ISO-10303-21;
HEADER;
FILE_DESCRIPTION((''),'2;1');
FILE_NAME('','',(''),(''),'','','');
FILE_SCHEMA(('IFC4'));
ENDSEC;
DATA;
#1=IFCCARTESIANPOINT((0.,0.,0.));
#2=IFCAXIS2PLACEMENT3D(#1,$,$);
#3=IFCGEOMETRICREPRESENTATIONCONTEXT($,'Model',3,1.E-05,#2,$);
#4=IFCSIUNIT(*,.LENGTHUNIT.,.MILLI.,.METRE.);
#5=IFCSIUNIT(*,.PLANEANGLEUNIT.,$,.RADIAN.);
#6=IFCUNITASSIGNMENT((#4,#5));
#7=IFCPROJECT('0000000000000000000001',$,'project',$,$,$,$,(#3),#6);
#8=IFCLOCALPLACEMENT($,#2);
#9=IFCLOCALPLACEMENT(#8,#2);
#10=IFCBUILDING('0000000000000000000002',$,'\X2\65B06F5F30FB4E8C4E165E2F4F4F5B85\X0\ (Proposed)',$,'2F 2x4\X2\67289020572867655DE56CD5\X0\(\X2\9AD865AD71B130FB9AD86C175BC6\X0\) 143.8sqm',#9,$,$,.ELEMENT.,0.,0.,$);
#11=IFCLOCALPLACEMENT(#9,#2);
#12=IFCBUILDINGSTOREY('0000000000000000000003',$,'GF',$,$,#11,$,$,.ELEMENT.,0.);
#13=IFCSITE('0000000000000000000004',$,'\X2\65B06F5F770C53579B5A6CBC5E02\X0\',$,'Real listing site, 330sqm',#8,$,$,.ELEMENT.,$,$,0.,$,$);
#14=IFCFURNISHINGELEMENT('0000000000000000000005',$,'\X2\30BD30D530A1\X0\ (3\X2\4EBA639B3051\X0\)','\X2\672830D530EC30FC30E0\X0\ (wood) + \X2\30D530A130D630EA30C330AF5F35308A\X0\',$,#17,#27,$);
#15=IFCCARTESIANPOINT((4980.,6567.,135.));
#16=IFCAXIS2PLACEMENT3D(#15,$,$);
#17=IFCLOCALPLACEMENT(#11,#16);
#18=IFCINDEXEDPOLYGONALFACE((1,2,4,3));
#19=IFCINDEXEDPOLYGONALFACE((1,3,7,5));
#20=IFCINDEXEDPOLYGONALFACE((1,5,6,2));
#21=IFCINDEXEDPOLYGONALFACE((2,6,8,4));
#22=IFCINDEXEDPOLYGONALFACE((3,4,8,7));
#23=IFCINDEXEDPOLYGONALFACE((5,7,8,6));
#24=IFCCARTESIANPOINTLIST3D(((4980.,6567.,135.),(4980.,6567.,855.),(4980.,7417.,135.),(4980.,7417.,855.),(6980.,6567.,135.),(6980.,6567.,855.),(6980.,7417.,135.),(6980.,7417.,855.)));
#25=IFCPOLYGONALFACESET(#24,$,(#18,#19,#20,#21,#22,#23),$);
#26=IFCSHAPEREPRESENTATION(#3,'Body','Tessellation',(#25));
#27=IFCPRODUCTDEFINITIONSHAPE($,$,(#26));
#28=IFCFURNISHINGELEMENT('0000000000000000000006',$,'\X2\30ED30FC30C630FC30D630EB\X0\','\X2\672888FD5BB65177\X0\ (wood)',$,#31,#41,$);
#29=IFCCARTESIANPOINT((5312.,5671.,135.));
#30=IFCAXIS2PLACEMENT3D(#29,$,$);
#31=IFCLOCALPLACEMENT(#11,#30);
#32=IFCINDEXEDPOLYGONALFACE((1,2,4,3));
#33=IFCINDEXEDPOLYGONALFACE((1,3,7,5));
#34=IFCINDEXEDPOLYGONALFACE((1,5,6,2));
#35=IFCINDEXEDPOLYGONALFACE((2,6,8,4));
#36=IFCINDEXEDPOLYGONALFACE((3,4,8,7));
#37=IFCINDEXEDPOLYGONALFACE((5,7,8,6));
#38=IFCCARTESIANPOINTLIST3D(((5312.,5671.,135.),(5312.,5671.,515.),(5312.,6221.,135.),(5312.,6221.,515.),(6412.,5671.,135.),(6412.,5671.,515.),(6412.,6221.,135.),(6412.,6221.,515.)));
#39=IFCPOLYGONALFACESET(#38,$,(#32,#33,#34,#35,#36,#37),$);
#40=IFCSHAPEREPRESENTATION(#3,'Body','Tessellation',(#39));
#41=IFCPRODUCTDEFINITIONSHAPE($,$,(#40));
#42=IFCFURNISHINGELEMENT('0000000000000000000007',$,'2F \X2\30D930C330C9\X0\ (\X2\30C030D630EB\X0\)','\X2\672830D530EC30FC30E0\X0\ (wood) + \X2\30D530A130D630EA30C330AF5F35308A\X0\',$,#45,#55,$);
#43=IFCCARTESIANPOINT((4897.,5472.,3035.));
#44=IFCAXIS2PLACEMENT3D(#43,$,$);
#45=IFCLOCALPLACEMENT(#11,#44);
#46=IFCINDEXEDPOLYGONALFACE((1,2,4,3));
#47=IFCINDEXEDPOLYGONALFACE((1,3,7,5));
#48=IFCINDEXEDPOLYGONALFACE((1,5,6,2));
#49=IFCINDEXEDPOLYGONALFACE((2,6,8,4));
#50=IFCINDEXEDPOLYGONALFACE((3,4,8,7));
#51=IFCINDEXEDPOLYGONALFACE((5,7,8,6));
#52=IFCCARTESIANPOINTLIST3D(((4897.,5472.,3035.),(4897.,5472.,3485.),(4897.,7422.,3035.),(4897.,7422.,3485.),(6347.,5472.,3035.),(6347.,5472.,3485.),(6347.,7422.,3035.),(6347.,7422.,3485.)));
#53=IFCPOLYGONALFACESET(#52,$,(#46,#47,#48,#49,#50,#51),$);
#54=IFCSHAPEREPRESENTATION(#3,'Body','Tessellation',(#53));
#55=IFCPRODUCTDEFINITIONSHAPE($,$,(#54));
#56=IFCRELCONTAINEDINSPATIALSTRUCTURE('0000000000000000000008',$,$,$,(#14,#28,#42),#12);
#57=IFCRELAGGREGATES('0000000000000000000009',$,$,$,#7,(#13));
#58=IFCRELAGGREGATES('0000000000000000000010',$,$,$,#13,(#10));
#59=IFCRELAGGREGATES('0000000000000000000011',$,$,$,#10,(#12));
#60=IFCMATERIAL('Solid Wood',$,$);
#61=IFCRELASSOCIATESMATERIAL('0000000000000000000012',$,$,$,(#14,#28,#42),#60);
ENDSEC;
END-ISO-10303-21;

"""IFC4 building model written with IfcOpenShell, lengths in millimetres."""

from ifc_helpers import new_model, si_unit, frame, frame_2d, origin, place, context, project, spatial, rectangle, extrude, material, element, save


model = new_model("IFC4")

# Units and contexts
model_context = context("Model", 3, precision=1e-05, world=origin())
ifc_project = project(units=[si_unit("LENGTHUNIT", "METRE", prefix="MILLI"), si_unit("PLANEANGLEUNIT", "RADIAN")], contexts=[model_context])

# Site, building, storey
site_placement = place(None, origin())
site = spatial("IfcSite", under=ifc_project, at=site_placement, Name="新潟県南魚沼市", ObjectType="Real listing site, 330sqm", CompositionType="ELEMENT", RefElevation=0.0)
building_placement = place(site_placement, origin())
building = spatial("IfcBuilding", under=site, at=building_placement, Name="新潟・二世帯住宅 (Proposed)", ObjectType="2F 2x4木造在来工法(高断熱・高気密) 143.8sqm", CompositionType="ELEMENT", ElevationOfRefHeight=0.0, ElevationOfTerrain=0.0)
storey_placement = place(building_placement, origin())
storey = spatial("IfcBuildingStorey", under=building, at=storey_placement, Name="GF", CompositionType="ELEMENT", Elevation=0.0)

# Shared definitions
ifc_material_1 = material(Name="Solid Wood")

# Furnishing elements
furnishing_1_placement = place(storey_placement, frame((4980.0, 6567.0, 135.0)))
element("IfcFurnishingElement", 1, at=furnishing_1_placement, inside=storey, material=ifc_material_1, Name="ソファ (3人掛け)", Description="木フレーム (wood) + ファブリック張り", context=model_context, shape_type="SweptSolid", body=[
    extrude(rectangle(XDim=2000.0, YDim=850.0, at=frame_2d((1000.0, 425.0))), frame((4980.0, 6567.0, 135.0)), (0.0, 0.0, 1.0), 720.0),
])
furnishing_2_placement = place(storey_placement, frame((5312.0, 5671.0, 135.0)))
element("IfcFurnishingElement", 2, at=furnishing_2_placement, inside=storey, material=ifc_material_1, Name="ローテーブル", Description="木製家具 (wood)", context=model_context, shape_type="SweptSolid", body=[
    extrude(rectangle(XDim=1100.0, YDim=550.0, at=frame_2d((550.0, 275.0))), frame((5312.0, 5671.0, 135.0)), (0.0, 0.0, 1.0), 380.0),
])
furnishing_3_placement = place(storey_placement, frame((4897.0, 5472.0, 3035.0)))
element("IfcFurnishingElement", 3, at=furnishing_3_placement, inside=storey, material=ifc_material_1, Name="2F ベッド (ダブル)", Description="木フレーム (wood) + ファブリック張り", context=model_context, shape_type="SweptSolid", body=[
    extrude(rectangle(XDim=1450.0, YDim=1950.0, at=frame_2d((725.0, 975.0))), frame((4897.0, 5472.0, 3035.0)), (0.0, 0.0, 1.0), 450.0),
])

save(model, "model.ifc")
